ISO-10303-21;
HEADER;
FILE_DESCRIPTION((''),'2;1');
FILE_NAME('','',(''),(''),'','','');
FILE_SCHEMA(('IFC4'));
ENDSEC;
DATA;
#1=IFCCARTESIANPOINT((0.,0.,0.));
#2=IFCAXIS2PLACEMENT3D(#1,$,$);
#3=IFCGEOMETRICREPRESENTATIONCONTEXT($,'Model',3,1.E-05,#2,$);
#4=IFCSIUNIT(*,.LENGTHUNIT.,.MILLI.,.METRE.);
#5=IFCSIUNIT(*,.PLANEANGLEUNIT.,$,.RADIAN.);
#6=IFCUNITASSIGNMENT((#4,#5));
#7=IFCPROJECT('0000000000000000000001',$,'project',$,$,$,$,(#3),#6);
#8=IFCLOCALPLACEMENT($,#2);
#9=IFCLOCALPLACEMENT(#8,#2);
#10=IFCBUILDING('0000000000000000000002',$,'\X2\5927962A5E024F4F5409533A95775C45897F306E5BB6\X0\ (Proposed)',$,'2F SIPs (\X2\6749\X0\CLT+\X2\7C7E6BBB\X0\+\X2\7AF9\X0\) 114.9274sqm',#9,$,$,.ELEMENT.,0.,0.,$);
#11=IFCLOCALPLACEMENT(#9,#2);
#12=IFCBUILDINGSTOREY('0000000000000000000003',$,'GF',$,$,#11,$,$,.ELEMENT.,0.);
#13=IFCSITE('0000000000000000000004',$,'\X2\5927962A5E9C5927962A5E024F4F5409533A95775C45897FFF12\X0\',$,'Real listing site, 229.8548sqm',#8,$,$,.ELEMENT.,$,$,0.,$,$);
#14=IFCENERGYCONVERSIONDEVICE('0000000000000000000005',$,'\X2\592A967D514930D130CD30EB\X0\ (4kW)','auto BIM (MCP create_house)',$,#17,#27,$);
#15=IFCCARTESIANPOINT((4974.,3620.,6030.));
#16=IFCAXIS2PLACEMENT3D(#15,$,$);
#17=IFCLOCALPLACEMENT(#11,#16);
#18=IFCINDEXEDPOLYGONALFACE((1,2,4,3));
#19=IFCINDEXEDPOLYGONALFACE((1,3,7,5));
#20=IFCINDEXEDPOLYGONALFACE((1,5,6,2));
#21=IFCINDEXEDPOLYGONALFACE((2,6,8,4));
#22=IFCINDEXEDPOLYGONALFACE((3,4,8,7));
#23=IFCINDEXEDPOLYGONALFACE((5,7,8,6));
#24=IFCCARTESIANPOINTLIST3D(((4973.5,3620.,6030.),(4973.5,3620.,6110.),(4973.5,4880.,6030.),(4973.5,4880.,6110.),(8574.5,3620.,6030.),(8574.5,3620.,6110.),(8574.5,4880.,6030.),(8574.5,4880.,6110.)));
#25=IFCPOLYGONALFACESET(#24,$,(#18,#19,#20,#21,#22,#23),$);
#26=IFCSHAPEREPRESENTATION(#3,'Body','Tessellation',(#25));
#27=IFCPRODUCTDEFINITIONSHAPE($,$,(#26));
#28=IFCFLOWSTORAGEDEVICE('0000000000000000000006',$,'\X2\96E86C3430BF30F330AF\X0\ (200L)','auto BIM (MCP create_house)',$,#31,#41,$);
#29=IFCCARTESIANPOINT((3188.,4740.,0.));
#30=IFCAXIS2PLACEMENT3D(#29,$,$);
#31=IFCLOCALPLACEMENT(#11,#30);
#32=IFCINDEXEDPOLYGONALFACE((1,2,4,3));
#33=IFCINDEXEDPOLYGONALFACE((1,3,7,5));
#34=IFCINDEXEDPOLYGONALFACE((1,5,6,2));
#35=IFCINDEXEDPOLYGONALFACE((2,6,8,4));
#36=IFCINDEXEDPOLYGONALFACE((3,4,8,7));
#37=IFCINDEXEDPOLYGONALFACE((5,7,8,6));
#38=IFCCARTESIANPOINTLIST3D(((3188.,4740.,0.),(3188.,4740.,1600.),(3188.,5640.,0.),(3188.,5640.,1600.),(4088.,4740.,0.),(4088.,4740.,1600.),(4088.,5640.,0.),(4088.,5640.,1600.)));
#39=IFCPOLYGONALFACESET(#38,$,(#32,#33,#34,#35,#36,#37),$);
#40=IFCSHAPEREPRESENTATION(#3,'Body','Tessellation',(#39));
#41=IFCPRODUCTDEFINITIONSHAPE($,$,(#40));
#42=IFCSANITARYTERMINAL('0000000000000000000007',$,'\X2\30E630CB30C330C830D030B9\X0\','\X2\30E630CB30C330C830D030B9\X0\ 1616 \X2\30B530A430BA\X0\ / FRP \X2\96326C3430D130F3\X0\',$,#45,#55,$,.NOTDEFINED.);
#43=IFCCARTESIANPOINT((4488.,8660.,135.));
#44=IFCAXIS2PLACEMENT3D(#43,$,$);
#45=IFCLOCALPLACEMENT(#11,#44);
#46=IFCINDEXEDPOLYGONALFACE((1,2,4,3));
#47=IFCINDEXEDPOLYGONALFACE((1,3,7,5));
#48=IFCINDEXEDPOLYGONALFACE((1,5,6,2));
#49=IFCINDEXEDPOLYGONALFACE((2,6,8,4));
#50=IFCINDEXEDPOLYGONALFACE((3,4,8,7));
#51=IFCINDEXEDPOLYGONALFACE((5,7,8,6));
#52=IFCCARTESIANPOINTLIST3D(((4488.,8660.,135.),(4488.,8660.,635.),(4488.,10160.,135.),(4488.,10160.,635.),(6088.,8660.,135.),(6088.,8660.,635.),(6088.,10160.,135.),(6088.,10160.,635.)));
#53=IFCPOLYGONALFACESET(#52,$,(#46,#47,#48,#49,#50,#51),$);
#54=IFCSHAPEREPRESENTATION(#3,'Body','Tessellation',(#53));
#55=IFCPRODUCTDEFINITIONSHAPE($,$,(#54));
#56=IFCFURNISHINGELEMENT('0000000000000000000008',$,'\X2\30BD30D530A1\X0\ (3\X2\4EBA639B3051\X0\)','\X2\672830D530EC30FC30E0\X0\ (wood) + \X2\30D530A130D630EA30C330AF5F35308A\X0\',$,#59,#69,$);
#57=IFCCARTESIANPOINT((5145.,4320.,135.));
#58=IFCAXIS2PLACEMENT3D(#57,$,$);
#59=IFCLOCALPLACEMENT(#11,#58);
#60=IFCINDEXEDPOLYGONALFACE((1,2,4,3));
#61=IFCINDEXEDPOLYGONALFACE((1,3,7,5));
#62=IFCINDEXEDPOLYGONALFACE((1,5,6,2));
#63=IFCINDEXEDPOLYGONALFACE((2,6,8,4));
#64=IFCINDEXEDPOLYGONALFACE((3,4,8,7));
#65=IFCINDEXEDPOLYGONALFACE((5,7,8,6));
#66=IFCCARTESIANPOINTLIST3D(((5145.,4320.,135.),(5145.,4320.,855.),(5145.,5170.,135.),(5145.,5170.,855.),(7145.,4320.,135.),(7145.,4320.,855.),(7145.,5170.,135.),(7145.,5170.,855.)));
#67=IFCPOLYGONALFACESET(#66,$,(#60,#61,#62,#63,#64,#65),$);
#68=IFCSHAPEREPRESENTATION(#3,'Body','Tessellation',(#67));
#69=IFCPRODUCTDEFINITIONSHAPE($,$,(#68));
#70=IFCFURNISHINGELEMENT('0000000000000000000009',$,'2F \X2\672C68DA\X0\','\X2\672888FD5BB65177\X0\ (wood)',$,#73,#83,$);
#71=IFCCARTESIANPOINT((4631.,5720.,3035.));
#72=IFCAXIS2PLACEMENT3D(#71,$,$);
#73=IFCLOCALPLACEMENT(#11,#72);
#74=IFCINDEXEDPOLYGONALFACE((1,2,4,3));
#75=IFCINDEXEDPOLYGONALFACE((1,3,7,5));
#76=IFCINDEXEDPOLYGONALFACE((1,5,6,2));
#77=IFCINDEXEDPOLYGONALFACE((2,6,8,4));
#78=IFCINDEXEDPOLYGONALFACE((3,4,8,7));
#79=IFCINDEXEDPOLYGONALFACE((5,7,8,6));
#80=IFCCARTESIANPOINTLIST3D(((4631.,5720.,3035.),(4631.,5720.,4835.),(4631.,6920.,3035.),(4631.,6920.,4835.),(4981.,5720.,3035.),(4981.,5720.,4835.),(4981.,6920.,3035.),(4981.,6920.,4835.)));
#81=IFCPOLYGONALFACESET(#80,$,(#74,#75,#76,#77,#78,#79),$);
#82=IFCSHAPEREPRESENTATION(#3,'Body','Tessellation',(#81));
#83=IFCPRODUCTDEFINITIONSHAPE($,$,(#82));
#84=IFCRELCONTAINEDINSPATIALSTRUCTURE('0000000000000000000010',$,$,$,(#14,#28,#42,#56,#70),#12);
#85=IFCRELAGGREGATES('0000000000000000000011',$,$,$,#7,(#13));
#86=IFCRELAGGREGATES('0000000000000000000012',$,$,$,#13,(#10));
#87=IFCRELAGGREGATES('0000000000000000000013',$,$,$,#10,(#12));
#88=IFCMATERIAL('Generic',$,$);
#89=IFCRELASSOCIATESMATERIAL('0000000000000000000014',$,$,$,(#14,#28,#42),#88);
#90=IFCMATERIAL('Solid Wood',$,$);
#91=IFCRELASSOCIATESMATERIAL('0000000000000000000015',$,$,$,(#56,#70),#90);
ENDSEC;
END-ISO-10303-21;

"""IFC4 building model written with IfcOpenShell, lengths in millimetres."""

from ifc_helpers import new_model, si_unit, frame, frame_2d, origin, place, context, project, spatial, rectangle, extrude, material, element, save


model = new_model("IFC4")

# Units and contexts
model_context = context("Model", 3, precision=1e-05, world=origin())
ifc_project = project(units=[si_unit("LENGTHUNIT", "METRE", prefix="MILLI"), si_unit("PLANEANGLEUNIT", "RADIAN")], contexts=[model_context])

# Site, building, storey
site_placement = place(None, origin())
site = spatial("IfcSite", under=ifc_project, at=site_placement, Name="大阪府大阪市住吉区長居西２", ObjectType="Real listing site, 229.8548sqm", CompositionType="ELEMENT", RefElevation=0.0)
building_placement = place(site_placement, origin())
building = spatial("IfcBuilding", under=site, at=building_placement, Name="大阪市住吉区長居西の家 (Proposed)", ObjectType="2F SIPs (杉CLT+籾殻+竹) 114.9274sqm", CompositionType="ELEMENT", ElevationOfRefHeight=0.0, ElevationOfTerrain=0.0)
storey_placement = place(building_placement, origin())
storey = spatial("IfcBuildingStorey", under=building, at=storey_placement, Name="GF", CompositionType="ELEMENT", Elevation=0.0)

# Shared definitions
ifc_material_1 = material(Name="Solid Wood")

# Energy conversion device
ifc_material_2 = material(Name="Generic")
energy_conversion_device_placement = place(storey_placement, frame((4974.0, 3620.0, 6030.0)))
element("IfcEnergyConversionDevice", 1, at=energy_conversion_device_placement, inside=storey, material=ifc_material_2, Name="太陽光パネル (4kW)", Description="auto BIM (MCP create_house)", context=model_context, shape_type="SweptSolid", body=[
    extrude(rectangle(XDim=3601.0, YDim=1260.0, at=frame_2d((1800.0, 630.0))), frame((4974.0, 3620.0, 6030.0)), (0.0, 0.0, 1.0), 80.0),
])

# Flow storage device
flow_storage_device_placement = place(storey_placement, frame((3188.0, 4740.0, 0.0)))
element("IfcFlowStorageDevice", 2, at=flow_storage_device_placement, inside=storey, material=ifc_material_2, Name="雨水タンク (200L)", Description="auto BIM (MCP create_house)", context=model_context, shape_type="SweptSolid", body=[
    extrude(rectangle(XDim=900.0, YDim=900.0, at=frame_2d((450.0, 450.0))), frame((3188.0, 4740.0, 0.0)), (0.0, 0.0, 1.0), 1600.0),
])

# Sanitary terminal
sanitary_terminal_placement = place(storey_placement, frame((4488.0, 8660.0, 135.0)))
element("IfcSanitaryTerminal", 3, at=sanitary_terminal_placement, inside=storey, material=ifc_material_2, Name="ユニットバス", Description="ユニットバス 1616 サイズ / FRP 防水パン", PredefinedType="NOTDEFINED", context=model_context, shape_type="SweptSolid", body=[
    extrude(rectangle(XDim=1600.0, YDim=1500.0, at=frame_2d((800.0, 750.0))), frame((4488.0, 8660.0, 135.0)), (0.0, 0.0, 1.0), 500.0),
])

# Furnishing elements
furnishing_1_placement = place(storey_placement, frame((5145.0, 4320.0, 135.0)))
element("IfcFurnishingElement", 4, at=furnishing_1_placement, inside=storey, material=ifc_material_1, Name="ソファ (3人掛け)", Description="木フレーム (wood) + ファブリック張り", context=model_context, shape_type="SweptSolid", body=[
    extrude(rectangle(XDim=2000.0, YDim=850.0, at=frame_2d((1000.0, 425.0))), frame((5145.0, 4320.0, 135.0)), (0.0, 0.0, 1.0), 720.0),
])
furnishing_2_placement = place(storey_placement, frame((4631.0, 5720.0, 3035.0)))
element("IfcFurnishingElement", 5, at=furnishing_2_placement, inside=storey, material=ifc_material_1, Name="2F 本棚", Description="木製家具 (wood)", context=model_context, shape_type="SweptSolid", body=[
    extrude(rectangle(XDim=350.0, YDim=1200.0, at=frame_2d((175.0, 600.0))), frame((4631.0, 5720.0, 3035.0)), (0.0, 0.0, 1.0), 1800.0),
])

save(model, "model.ifc")
